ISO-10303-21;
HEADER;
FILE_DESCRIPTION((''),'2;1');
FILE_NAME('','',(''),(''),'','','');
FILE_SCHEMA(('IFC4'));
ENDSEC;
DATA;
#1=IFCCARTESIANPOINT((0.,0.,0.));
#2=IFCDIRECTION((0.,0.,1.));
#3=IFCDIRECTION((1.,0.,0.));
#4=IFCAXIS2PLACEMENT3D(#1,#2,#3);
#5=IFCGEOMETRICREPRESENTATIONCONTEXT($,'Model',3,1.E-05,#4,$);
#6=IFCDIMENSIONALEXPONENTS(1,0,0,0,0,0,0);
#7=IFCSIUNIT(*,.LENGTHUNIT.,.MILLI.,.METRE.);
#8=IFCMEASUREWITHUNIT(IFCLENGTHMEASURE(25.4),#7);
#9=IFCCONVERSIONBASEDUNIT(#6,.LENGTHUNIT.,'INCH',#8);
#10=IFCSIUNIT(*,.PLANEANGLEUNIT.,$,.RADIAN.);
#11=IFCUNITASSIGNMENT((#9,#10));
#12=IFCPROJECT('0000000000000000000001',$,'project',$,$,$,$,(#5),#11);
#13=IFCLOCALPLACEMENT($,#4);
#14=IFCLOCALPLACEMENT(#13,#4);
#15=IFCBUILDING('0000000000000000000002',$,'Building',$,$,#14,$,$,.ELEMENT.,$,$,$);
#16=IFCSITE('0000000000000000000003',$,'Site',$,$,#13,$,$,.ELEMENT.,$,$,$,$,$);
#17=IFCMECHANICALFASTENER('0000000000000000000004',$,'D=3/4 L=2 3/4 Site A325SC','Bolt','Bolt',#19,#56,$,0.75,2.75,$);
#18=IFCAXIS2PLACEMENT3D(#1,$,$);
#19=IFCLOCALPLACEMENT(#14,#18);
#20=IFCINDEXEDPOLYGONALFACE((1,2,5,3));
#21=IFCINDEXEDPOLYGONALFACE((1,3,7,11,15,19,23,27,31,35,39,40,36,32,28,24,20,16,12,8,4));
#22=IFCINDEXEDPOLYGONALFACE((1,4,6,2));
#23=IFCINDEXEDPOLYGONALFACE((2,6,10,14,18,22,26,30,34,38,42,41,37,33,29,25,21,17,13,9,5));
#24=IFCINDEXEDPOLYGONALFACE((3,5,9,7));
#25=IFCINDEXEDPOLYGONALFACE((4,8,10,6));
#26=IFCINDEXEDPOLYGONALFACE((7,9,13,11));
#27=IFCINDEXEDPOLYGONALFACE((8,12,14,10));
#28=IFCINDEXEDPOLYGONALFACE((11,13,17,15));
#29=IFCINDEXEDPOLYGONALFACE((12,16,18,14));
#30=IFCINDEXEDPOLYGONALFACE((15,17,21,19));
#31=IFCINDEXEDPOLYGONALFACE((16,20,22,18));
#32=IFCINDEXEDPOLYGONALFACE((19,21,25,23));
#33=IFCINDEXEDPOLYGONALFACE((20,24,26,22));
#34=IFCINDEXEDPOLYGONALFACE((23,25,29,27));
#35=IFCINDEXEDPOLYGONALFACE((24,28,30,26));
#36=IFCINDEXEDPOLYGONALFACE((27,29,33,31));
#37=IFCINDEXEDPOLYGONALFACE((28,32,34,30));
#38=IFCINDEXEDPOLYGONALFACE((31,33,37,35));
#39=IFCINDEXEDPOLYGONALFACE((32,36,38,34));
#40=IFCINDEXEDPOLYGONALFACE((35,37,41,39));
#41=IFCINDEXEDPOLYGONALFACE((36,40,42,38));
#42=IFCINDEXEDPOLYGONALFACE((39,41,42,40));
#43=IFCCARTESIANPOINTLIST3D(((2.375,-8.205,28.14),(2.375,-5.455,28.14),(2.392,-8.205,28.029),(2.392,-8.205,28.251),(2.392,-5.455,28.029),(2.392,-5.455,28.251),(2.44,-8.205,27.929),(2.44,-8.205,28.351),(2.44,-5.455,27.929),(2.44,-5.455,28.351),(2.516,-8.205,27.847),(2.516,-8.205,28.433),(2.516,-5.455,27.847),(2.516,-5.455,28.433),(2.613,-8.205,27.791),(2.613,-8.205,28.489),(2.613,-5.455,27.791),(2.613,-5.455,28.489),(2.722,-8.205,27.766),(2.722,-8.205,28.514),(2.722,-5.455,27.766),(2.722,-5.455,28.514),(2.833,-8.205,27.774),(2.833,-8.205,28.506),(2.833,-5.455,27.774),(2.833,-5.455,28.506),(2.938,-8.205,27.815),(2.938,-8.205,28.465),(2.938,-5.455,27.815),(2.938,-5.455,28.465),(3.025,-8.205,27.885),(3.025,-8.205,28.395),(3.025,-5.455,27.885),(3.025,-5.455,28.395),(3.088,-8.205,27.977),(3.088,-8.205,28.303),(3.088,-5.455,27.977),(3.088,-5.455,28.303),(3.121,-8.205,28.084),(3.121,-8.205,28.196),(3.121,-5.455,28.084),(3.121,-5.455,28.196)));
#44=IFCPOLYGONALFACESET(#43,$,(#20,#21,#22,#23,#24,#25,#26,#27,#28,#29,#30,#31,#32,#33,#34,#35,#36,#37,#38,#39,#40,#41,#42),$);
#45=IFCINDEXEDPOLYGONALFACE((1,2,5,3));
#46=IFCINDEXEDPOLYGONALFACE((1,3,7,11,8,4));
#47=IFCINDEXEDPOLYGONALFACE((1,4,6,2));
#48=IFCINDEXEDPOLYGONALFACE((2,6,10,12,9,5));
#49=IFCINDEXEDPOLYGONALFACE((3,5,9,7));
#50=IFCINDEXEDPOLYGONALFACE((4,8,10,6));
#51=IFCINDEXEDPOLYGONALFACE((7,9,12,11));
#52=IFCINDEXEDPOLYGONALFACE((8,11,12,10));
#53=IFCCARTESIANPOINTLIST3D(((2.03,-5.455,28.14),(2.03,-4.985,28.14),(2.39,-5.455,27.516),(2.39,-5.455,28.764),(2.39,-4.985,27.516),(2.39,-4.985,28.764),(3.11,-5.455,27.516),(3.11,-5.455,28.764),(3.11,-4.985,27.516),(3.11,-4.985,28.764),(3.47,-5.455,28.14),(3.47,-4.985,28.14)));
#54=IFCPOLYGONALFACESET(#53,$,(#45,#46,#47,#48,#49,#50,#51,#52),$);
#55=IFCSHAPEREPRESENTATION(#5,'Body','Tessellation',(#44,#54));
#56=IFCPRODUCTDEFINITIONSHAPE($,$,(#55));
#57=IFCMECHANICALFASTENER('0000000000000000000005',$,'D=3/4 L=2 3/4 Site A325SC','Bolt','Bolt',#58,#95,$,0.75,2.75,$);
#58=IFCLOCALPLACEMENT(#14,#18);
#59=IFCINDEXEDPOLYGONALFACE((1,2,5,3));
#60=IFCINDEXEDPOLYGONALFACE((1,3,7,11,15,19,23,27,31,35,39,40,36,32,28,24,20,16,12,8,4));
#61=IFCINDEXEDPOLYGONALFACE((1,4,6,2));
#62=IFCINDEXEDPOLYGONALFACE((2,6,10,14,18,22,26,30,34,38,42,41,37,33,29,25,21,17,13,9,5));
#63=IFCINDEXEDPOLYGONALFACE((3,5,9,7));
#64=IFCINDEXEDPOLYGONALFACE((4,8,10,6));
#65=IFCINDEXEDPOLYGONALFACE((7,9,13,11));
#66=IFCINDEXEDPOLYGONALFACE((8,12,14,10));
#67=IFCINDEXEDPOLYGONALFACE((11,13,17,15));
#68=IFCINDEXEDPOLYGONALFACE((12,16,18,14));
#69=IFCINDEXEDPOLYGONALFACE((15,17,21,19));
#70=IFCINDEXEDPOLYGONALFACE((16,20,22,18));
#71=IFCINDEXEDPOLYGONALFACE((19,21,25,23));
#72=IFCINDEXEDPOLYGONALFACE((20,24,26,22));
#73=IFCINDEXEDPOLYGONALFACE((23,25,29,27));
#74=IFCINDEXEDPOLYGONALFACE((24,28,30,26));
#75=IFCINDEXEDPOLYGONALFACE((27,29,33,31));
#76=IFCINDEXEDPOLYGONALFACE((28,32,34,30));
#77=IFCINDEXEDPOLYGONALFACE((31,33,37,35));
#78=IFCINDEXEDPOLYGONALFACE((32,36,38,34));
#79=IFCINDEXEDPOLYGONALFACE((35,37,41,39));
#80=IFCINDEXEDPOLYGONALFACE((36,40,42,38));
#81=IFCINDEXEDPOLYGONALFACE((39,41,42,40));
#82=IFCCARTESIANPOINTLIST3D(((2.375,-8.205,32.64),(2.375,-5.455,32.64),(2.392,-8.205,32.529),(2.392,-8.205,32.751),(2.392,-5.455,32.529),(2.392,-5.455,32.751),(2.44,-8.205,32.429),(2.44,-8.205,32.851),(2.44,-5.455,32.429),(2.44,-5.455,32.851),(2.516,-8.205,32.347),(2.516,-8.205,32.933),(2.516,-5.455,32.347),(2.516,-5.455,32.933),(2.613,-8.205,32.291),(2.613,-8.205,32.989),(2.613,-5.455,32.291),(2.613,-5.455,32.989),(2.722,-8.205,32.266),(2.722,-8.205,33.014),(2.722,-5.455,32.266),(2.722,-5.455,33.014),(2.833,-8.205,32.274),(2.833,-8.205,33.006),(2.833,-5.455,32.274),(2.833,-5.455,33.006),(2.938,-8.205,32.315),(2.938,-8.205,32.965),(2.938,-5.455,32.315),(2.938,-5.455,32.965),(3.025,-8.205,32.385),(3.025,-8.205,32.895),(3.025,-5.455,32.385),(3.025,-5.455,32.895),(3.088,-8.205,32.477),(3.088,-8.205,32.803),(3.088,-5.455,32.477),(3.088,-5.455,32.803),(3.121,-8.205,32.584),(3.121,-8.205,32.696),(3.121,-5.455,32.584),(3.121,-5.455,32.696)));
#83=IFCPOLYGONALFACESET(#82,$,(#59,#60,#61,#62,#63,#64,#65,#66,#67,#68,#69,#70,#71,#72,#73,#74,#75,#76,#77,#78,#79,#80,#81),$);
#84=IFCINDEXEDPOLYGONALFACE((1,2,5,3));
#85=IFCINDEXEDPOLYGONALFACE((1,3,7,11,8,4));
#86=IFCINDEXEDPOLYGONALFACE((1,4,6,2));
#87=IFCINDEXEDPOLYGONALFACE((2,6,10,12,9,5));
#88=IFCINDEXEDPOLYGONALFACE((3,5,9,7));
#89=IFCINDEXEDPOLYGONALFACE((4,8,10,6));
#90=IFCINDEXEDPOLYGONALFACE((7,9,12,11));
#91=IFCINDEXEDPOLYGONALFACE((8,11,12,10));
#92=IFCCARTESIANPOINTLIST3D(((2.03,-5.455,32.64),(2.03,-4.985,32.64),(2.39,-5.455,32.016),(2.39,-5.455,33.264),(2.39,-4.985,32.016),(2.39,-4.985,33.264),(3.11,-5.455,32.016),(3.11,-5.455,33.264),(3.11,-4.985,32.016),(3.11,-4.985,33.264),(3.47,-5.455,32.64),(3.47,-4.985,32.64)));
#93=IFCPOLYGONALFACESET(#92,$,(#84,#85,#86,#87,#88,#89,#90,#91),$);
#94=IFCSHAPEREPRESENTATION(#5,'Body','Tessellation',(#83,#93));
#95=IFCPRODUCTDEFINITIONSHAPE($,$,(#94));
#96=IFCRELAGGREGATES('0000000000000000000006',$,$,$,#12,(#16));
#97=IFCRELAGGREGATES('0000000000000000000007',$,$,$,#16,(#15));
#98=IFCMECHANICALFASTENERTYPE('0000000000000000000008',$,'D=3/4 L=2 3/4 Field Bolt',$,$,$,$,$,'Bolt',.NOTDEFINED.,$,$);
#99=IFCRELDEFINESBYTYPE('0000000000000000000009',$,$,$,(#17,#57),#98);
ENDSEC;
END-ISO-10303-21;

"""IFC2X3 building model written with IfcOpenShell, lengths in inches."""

from ifc_helpers import new_model, entity, si_unit, converted_unit, frame, origin_with_axes, origin_2d_with_axis, place, context, project, spatial, polyline, circle, outline, extrude, source, transform, mapped, type_object, type_shapes, element, save


model = new_model("IFC2X3")

# Units and contexts
model_context = context("Model", 3, precision=1e-05, world=origin_with_axes())
ifc_project = project(units=[converted_unit("LENGTHUNIT", "INCH", entity("IfcLengthMeasure", 25.4), si_unit("LENGTHUNIT", "METRE", prefix="MILLI"), dimensions=[1, 0, 0, 0, 0, 0, 0]), si_unit("PLANEANGLEUNIT", "RADIAN")], contexts=[model_context])

# Site, building
site_placement = place(None, origin_with_axes())
site = spatial("IfcSite", under=ifc_project, at=site_placement, Name="Site", CompositionType="ELEMENT")
building_placement = place(site_placement, origin_with_axes())
building = spatial("IfcBuilding", under=site, at=building_placement, Name="Building", CompositionType="ELEMENT")

# Shared definitions
assembly_1_placement = place(building_placement, frame((0.0, 0.0, 46.0), z_axis=(0.0, 0.0, 1.0), x_axis=(0.0, -1.0, 0.0)))

# Mechanical fasteners
mechanical_fastener_type_1 = type_object("IfcMechanicalFastenerType", Name="D=3/4 L=2 3/4 Field Bolt", ElementType="Bolt")
shared_shape_1 = source(origin_with_axes(), model_context, "Body", "SweptSolid", [
    extrude(circle(Radius=0.375, at=origin_2d_with_axis()), frame((0.0, 0.0, 0.0), z_axis=(1.0, 0.0, 0.0), x_axis=(0.0, 1.0, 0.0)), (0.0, 0.0, 1.0), 2.75),
    extrude(outline(polyline([(-0.72, 0.0), (-0.36, 0.624), (0.36, 0.624), (0.72, 0.0), (0.36, -0.624), (-0.36, -0.624), (-0.72, 0.0)])), frame((0.0, 0.0, 0.0), z_axis=(1.0, 0.0, 0.0), x_axis=(0.0, 1.0, 0.0)), (0.0, 0.0, -1.0), 0.47),
])
type_shapes(mechanical_fastener_type_1, [shared_shape_1])
placement_1 = place(assembly_1_placement, frame((5.455, -2.75, 2.0), z_axis=(0.0, 0.0, -1.0), x_axis=(1.0, 0.0, 0.0)))
for number, where, z_axis, x_axis, name in (
    (1, (0.0, -5.5, 19.86), (0.0, 0.0, 1.0), (1.0, 0.0, 0.0), "D=3/4 L=2 3/4 Site A325SC"),
    (2, (0.0, -5.5, 15.36), (0.0, 0.0, 1.0), (1.0, 0.0, 0.0), "D=3/4 L=2 3/4 Site A325SC"),
):
    element("IfcMechanicalFastener", number, at=place(placement_1, frame(where, z_axis=z_axis, x_axis=x_axis)), type_object=mechanical_fastener_type_1, Name=name, Description="Bolt", ObjectType="Bolt", NominalDiameter=0.75, NominalLength=2.75, context=model_context, shape_type="MappedRepresentation", body=[
        mapped(shared_shape_1, transform((0.0, 0.0, 0.0), scale=1.0)),
    ])

save(model, "model.ifc")
